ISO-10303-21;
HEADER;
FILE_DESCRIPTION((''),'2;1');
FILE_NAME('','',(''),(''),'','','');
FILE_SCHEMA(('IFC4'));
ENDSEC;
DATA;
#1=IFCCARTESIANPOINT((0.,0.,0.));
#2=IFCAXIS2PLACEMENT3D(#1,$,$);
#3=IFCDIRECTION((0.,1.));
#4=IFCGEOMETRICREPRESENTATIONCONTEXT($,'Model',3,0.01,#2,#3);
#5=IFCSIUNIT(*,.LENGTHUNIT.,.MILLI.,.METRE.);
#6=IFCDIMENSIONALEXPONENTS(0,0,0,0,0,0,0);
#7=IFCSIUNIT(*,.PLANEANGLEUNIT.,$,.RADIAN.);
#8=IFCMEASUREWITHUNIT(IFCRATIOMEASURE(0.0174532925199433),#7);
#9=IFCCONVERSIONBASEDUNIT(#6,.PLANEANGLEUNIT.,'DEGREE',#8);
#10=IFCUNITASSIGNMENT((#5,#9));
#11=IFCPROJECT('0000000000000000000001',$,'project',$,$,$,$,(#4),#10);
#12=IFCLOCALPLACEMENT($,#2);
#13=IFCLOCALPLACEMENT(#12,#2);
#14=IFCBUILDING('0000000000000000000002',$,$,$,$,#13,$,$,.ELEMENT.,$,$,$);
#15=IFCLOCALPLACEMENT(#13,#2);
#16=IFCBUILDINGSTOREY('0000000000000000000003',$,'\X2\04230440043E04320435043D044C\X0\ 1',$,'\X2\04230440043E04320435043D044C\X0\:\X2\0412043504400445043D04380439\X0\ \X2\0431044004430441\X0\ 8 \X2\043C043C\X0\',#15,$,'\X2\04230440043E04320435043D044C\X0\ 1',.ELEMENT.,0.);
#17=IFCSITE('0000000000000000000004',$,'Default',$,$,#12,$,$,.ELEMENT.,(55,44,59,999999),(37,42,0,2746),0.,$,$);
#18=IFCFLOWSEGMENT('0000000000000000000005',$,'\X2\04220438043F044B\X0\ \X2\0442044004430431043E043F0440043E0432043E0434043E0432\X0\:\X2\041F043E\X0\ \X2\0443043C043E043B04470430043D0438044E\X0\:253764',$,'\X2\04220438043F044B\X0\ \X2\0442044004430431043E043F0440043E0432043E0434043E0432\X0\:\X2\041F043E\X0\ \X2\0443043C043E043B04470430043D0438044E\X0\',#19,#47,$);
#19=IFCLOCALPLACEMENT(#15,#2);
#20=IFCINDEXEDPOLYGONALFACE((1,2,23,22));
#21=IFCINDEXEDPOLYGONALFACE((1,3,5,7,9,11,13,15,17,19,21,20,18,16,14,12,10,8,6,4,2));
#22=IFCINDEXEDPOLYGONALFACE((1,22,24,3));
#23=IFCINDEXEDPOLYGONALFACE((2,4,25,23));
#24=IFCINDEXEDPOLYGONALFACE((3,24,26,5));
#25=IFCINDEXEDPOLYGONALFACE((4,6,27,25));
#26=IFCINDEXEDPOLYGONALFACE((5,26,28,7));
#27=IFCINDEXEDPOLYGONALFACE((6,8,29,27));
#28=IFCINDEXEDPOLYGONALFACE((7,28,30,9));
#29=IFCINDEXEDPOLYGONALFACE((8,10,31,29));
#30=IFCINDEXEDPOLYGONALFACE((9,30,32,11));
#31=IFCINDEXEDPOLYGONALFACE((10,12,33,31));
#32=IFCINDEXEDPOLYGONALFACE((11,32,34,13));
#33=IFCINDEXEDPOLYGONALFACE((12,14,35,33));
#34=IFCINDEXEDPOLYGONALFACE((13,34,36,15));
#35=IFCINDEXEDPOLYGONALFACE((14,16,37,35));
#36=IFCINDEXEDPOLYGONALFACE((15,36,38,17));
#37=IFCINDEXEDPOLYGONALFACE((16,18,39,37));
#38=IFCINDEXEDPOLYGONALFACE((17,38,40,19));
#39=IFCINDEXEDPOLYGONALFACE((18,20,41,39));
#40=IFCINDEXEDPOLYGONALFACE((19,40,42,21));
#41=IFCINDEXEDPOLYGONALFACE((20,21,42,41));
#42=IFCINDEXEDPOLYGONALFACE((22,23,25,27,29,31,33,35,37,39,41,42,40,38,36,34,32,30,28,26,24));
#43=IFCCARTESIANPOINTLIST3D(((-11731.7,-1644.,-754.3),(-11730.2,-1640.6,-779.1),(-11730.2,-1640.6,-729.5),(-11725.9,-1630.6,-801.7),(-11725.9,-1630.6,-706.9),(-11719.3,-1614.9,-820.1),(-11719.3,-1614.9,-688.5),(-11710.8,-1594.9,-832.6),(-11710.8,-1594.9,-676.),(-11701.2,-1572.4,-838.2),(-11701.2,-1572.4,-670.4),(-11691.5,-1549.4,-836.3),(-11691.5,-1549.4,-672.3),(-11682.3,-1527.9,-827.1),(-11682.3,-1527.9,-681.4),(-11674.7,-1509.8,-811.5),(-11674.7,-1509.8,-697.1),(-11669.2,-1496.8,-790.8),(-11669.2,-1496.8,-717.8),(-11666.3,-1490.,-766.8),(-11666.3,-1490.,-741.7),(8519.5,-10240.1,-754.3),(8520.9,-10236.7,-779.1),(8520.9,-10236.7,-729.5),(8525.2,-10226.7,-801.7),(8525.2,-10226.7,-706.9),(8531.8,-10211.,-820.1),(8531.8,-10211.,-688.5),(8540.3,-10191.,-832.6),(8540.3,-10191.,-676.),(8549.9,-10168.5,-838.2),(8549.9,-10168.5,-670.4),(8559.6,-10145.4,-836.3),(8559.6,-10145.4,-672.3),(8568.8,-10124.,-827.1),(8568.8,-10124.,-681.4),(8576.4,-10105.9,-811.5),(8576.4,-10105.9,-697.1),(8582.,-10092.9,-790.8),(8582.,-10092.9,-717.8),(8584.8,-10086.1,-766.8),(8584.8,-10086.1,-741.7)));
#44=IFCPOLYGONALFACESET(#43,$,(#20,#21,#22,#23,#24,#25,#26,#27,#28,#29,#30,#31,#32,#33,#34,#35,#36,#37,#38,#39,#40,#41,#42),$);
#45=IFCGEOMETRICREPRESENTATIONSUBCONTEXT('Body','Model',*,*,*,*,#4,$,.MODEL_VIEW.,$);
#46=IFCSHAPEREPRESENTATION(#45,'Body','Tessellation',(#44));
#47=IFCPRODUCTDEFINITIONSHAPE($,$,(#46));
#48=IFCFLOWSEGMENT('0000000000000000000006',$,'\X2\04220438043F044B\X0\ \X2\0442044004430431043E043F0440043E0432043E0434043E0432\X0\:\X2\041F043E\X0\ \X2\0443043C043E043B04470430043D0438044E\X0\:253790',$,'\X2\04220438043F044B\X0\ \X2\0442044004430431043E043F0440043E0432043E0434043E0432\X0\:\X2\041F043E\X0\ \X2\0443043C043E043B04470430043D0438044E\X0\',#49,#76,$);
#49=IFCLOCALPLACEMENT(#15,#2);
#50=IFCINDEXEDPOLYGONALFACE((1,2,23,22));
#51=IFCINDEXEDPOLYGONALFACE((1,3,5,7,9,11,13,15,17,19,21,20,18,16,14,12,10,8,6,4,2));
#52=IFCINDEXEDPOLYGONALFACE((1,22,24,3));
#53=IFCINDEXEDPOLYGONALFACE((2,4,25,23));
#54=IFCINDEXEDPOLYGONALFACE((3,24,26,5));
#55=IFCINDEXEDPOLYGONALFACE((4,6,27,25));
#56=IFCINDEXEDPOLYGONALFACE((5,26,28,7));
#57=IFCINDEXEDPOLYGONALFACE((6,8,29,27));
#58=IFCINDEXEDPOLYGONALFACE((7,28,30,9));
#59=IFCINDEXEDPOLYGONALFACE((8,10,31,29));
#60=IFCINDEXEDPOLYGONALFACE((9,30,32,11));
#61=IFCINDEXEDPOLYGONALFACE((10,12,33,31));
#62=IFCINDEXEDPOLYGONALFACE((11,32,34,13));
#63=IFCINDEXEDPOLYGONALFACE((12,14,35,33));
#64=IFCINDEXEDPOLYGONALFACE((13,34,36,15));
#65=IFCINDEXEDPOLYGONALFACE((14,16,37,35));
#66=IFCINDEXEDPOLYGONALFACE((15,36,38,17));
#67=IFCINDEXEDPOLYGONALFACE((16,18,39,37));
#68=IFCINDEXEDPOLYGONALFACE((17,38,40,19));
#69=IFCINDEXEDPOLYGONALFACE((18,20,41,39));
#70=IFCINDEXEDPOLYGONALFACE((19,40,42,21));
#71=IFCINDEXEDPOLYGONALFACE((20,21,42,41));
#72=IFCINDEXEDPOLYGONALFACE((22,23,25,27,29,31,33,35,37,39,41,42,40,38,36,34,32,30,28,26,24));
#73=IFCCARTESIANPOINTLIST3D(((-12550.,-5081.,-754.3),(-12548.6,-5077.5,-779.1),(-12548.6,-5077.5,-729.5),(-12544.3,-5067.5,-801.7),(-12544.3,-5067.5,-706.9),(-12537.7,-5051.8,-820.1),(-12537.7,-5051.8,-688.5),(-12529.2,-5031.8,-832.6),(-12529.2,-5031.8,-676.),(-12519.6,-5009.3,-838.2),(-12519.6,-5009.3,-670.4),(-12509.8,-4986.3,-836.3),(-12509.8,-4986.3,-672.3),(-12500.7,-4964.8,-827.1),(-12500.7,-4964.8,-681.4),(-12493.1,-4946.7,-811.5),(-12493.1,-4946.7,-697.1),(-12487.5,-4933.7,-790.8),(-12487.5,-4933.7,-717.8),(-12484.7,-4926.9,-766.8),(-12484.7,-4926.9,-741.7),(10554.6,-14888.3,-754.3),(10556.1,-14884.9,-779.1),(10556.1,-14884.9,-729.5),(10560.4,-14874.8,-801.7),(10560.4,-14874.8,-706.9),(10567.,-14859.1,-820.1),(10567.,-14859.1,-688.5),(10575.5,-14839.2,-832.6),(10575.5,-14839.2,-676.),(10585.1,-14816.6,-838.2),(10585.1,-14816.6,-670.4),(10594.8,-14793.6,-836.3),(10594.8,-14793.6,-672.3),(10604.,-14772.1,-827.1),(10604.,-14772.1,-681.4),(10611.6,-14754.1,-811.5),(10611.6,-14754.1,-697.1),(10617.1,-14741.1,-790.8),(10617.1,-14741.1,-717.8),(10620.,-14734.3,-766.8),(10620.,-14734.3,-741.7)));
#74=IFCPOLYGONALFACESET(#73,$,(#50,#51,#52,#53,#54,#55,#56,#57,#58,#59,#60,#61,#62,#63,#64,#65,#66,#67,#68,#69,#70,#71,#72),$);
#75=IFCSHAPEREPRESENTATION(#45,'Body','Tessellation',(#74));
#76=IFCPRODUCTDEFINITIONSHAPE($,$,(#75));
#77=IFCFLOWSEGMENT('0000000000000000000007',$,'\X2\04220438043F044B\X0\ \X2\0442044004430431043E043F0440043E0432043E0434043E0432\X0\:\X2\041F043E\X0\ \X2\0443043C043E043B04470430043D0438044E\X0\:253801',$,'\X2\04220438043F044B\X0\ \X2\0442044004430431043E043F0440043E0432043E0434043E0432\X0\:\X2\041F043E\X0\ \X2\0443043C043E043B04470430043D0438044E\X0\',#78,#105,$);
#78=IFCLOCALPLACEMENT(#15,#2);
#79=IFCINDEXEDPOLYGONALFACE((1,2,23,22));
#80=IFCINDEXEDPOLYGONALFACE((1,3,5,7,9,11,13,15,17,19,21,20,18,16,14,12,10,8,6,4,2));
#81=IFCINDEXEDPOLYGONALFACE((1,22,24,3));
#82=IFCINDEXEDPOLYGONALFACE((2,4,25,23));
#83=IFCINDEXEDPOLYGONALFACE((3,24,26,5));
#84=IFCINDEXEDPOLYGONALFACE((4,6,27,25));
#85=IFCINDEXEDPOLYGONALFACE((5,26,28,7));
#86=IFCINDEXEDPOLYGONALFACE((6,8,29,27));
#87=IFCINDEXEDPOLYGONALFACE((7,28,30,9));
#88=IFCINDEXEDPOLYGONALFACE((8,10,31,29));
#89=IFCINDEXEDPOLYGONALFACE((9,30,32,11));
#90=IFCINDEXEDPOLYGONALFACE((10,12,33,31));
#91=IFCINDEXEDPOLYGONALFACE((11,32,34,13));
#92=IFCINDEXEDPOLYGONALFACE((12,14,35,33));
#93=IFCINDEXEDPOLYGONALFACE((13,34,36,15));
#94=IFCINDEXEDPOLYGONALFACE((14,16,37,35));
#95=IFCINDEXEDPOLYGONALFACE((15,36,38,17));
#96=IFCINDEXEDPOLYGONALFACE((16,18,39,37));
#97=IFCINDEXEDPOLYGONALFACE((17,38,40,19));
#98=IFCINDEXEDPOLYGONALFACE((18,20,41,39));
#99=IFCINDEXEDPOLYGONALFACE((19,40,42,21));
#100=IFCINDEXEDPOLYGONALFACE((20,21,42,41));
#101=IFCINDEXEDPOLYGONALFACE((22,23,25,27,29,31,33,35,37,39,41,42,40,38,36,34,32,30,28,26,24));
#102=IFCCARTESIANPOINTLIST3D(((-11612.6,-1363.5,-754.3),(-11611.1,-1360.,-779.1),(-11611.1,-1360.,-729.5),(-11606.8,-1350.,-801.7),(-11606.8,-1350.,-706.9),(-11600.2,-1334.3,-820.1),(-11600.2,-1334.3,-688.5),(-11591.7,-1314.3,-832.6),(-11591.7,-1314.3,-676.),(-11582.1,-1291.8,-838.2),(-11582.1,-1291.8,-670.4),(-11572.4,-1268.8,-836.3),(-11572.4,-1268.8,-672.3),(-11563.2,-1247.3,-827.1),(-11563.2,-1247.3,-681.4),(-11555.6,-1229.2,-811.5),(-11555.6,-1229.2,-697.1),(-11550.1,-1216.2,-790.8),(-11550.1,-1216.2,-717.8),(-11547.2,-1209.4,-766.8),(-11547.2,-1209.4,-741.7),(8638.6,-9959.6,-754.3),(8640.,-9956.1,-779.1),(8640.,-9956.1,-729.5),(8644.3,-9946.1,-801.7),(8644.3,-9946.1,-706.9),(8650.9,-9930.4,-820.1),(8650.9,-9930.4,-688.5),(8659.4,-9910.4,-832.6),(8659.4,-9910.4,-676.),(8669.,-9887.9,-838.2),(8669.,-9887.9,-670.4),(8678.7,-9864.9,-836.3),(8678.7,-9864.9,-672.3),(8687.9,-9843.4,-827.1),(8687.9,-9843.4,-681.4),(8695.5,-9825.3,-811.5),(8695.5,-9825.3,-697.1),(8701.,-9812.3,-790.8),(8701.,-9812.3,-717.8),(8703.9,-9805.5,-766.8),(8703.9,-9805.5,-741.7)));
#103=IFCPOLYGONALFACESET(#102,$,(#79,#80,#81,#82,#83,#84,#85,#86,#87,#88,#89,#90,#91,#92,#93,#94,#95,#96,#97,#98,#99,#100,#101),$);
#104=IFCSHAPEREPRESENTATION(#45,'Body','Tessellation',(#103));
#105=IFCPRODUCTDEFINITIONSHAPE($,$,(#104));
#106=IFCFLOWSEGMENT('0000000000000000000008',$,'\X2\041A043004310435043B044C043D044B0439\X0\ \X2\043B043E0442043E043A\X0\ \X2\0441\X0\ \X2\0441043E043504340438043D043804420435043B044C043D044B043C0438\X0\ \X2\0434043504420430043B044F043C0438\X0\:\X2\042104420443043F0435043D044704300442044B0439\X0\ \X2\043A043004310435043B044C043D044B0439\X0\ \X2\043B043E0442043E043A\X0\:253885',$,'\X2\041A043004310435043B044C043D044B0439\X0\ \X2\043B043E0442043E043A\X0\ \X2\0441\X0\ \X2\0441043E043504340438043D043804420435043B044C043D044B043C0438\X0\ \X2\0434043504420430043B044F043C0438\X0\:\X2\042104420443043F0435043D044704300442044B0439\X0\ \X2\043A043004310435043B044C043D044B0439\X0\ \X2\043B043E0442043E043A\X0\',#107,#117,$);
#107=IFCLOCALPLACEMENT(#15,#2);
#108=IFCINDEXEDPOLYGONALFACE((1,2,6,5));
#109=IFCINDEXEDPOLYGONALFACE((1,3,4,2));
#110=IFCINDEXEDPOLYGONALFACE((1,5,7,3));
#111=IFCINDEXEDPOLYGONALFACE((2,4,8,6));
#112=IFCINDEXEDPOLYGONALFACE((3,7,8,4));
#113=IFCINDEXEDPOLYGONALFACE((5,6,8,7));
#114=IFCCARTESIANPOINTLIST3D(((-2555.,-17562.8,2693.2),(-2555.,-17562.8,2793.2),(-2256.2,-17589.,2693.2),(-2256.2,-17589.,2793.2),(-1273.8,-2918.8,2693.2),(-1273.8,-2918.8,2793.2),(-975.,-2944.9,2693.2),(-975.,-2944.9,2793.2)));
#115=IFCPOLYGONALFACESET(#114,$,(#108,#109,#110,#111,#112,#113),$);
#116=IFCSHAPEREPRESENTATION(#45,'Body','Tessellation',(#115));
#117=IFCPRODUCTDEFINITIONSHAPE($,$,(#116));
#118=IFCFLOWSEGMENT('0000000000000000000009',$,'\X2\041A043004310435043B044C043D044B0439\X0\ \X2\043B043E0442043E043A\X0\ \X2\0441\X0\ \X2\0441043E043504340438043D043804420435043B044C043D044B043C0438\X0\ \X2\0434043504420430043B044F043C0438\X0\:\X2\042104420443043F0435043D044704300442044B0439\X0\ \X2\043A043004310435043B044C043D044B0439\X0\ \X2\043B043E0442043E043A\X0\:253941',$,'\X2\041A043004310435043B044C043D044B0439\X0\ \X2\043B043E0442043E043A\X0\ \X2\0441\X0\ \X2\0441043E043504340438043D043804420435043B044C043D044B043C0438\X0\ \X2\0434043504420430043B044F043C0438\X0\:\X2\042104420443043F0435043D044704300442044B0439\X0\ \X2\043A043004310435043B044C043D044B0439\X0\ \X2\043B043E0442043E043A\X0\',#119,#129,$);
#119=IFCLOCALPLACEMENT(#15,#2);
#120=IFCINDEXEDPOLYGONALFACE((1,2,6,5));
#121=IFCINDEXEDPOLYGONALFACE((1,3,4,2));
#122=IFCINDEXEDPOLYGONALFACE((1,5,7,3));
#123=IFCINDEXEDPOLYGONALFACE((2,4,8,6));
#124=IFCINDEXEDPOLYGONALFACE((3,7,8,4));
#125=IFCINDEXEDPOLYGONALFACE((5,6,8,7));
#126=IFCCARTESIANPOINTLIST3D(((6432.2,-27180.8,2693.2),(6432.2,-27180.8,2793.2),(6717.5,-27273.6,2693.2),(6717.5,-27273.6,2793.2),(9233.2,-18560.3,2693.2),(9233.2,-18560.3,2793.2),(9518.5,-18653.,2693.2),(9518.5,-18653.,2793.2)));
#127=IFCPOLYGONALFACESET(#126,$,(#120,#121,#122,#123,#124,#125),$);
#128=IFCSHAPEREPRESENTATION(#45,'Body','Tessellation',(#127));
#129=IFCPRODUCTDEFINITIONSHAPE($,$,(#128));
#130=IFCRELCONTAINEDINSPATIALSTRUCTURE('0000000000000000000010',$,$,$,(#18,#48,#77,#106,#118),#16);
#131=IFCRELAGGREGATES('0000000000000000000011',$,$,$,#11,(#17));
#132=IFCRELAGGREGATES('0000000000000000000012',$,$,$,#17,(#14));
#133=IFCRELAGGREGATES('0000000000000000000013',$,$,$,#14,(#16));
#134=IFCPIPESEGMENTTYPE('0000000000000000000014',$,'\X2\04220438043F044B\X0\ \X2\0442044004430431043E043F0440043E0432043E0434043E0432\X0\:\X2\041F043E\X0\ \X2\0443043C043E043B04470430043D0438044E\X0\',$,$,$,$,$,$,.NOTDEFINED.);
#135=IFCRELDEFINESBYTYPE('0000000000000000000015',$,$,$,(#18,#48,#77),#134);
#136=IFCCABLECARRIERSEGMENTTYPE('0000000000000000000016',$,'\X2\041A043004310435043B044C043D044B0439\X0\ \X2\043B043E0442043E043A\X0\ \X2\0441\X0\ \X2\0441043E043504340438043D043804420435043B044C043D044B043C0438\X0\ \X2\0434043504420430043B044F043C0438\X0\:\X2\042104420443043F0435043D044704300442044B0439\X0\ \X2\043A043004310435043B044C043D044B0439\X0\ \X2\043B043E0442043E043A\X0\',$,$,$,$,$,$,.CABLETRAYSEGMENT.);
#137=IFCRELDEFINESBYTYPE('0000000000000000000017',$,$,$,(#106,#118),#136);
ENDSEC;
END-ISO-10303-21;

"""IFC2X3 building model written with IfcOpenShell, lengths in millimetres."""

from ifc_helpers import new_model, entity, si_unit, converted_unit, direction, frame, origin, origin_2d_with_axis, place, context, subcontext, project, spatial, rectangle, circle, extrude, type_object, element, save


model = new_model("IFC2X3")

# Units and contexts
model_context = context("Model", 3, precision=0.01, world=origin(), true_north=direction((0.0, 1.0)))
body_context = subcontext(model_context, "Body", "Model", "MODEL_VIEW")
ifc_project = project(units=[si_unit("LENGTHUNIT", "METRE", prefix="MILLI"), converted_unit("PLANEANGLEUNIT", "DEGREE", entity("IfcRatioMeasure", 0.0174532925199433), si_unit("PLANEANGLEUNIT", "RADIAN"), dimensions=[0, 0, 0, 0, 0, 0, 0])], contexts=[model_context])

# Site, building, storey
site_placement = place(None, origin())
site = spatial("IfcSite", under=ifc_project, at=site_placement, Name="Default", CompositionType="ELEMENT", RefLatitude=(55, 44, 59, 999999), RefLongitude=(37, 42, 0, 2746), RefElevation=0.0)
building_placement = place(site_placement, origin())
building = spatial("IfcBuilding", under=site, at=building_placement, CompositionType="ELEMENT")
storey_placement = place(building_placement, origin())
storey = spatial("IfcBuildingStorey", under=building, at=storey_placement, Name="Уровень 1", ObjectType="Уровень:Верхний брус 8 мм", LongName="Уровень 1", CompositionType="ELEMENT", Elevation=0.0)

# Flow segments
pipe_segment_type = type_object("IfcPipeSegmentType", Name="Типы трубопроводов:По умолчанию", PredefinedType="NOTDEFINED")
flow_segment_1_placement = place(storey_placement, origin())
element("IfcFlowSegment", 1, at=flow_segment_1_placement, inside=storey, type_object=pipe_segment_type, Name="Типы трубопроводов:По умолчанию:253764", ObjectType="Типы трубопроводов:По умолчанию", context=body_context, shape_type="SweptSolid", body=[
    extrude(circle(Radius=84.1, at=origin_2d_with_axis()), frame((8552.3, -10162.7, -754.3), z_axis=(-0.920505, 0.390731, 0.0), x_axis=(-0.390731, -0.920505, 0.0)), (0.0, 0.0, 1.0), 22000.0),
])
flow_segment_2_placement = place(storey_placement, origin())
element("IfcFlowSegment", 2, at=flow_segment_2_placement, inside=storey, type_object=pipe_segment_type, Name="Типы трубопроводов:По умолчанию:253790", ObjectType="Типы трубопроводов:По умолчанию", context=body_context, shape_type="SweptSolid", body=[
    extrude(circle(Radius=84.1, at=origin_2d_with_axis()), frame((-12517.2, -5003.5, -754.3), z_axis=(0.920505, -0.390731, 0.0), x_axis=(-0.390731, -0.920505, 0.0)), (0.0, 0.0, 1.0), 25100.0),
])
flow_segment_3_placement = place(storey_placement, origin())
element("IfcFlowSegment", 3, at=flow_segment_3_placement, inside=storey, type_object=pipe_segment_type, Name="Типы трубопроводов:По умолчанию:253801", ObjectType="Типы трубопроводов:По умолчанию", context=body_context, shape_type="SweptSolid", body=[
    extrude(circle(Radius=84.1, at=origin_2d_with_axis()), frame((8671.4, -9882.1, -754.3), z_axis=(-0.920505, 0.390731, 0.0), x_axis=(-0.390731, -0.920505, 0.0)), (0.0, 0.0, 1.0), 22000.0),
])
cable_carrier_segment_type = type_object("IfcCableCarrierSegmentType", Name="Кабельный лоток с соединительными деталями:Ступенчатый кабельный лоток", PredefinedType="CABLETRAYSEGMENT")
flow_segment_4_placement = place(storey_placement, origin())
element("IfcFlowSegment", 4, at=flow_segment_4_placement, inside=storey, type_object=cable_carrier_segment_type, Name="Кабельный лоток с соединительными деталями:Ступенчатый кабельный лоток:253885", ObjectType="Кабельный лоток с соединительными деталями:Ступенчатый кабельный лоток", context=body_context, shape_type="SweptSolid", body=[
    extrude(rectangle(XDim=14700.0, YDim=300.0, at=origin_2d_with_axis()), frame((-1765.0, -10253.9, 2693.2), z_axis=(0.0, 0.0, 1.0), x_axis=(-0.087156, -0.996195, 0.0)), (0.0, 0.0, 1.0), 100.0),
])
flow_segment_5_placement = place(storey_placement, origin())
element("IfcFlowSegment", 5, at=flow_segment_5_placement, inside=storey, type_object=cable_carrier_segment_type, Name="Кабельный лоток с соединительными деталями:Ступенчатый кабельный лоток:253941", ObjectType="Кабельный лоток с соединительными деталями:Ступенчатый кабельный лоток", context=body_context, shape_type="SweptSolid", body=[
    extrude(rectangle(XDim=9064.2, YDim=300.0, at=origin_2d_with_axis()), frame((7975.4, -22916.9, 2693.2), z_axis=(0.0, 0.0, 1.0), x_axis=(0.309017, 0.951057, 0.0)), (0.0, 0.0, 1.0), 100.0),
])

save(model, "model.ifc")
